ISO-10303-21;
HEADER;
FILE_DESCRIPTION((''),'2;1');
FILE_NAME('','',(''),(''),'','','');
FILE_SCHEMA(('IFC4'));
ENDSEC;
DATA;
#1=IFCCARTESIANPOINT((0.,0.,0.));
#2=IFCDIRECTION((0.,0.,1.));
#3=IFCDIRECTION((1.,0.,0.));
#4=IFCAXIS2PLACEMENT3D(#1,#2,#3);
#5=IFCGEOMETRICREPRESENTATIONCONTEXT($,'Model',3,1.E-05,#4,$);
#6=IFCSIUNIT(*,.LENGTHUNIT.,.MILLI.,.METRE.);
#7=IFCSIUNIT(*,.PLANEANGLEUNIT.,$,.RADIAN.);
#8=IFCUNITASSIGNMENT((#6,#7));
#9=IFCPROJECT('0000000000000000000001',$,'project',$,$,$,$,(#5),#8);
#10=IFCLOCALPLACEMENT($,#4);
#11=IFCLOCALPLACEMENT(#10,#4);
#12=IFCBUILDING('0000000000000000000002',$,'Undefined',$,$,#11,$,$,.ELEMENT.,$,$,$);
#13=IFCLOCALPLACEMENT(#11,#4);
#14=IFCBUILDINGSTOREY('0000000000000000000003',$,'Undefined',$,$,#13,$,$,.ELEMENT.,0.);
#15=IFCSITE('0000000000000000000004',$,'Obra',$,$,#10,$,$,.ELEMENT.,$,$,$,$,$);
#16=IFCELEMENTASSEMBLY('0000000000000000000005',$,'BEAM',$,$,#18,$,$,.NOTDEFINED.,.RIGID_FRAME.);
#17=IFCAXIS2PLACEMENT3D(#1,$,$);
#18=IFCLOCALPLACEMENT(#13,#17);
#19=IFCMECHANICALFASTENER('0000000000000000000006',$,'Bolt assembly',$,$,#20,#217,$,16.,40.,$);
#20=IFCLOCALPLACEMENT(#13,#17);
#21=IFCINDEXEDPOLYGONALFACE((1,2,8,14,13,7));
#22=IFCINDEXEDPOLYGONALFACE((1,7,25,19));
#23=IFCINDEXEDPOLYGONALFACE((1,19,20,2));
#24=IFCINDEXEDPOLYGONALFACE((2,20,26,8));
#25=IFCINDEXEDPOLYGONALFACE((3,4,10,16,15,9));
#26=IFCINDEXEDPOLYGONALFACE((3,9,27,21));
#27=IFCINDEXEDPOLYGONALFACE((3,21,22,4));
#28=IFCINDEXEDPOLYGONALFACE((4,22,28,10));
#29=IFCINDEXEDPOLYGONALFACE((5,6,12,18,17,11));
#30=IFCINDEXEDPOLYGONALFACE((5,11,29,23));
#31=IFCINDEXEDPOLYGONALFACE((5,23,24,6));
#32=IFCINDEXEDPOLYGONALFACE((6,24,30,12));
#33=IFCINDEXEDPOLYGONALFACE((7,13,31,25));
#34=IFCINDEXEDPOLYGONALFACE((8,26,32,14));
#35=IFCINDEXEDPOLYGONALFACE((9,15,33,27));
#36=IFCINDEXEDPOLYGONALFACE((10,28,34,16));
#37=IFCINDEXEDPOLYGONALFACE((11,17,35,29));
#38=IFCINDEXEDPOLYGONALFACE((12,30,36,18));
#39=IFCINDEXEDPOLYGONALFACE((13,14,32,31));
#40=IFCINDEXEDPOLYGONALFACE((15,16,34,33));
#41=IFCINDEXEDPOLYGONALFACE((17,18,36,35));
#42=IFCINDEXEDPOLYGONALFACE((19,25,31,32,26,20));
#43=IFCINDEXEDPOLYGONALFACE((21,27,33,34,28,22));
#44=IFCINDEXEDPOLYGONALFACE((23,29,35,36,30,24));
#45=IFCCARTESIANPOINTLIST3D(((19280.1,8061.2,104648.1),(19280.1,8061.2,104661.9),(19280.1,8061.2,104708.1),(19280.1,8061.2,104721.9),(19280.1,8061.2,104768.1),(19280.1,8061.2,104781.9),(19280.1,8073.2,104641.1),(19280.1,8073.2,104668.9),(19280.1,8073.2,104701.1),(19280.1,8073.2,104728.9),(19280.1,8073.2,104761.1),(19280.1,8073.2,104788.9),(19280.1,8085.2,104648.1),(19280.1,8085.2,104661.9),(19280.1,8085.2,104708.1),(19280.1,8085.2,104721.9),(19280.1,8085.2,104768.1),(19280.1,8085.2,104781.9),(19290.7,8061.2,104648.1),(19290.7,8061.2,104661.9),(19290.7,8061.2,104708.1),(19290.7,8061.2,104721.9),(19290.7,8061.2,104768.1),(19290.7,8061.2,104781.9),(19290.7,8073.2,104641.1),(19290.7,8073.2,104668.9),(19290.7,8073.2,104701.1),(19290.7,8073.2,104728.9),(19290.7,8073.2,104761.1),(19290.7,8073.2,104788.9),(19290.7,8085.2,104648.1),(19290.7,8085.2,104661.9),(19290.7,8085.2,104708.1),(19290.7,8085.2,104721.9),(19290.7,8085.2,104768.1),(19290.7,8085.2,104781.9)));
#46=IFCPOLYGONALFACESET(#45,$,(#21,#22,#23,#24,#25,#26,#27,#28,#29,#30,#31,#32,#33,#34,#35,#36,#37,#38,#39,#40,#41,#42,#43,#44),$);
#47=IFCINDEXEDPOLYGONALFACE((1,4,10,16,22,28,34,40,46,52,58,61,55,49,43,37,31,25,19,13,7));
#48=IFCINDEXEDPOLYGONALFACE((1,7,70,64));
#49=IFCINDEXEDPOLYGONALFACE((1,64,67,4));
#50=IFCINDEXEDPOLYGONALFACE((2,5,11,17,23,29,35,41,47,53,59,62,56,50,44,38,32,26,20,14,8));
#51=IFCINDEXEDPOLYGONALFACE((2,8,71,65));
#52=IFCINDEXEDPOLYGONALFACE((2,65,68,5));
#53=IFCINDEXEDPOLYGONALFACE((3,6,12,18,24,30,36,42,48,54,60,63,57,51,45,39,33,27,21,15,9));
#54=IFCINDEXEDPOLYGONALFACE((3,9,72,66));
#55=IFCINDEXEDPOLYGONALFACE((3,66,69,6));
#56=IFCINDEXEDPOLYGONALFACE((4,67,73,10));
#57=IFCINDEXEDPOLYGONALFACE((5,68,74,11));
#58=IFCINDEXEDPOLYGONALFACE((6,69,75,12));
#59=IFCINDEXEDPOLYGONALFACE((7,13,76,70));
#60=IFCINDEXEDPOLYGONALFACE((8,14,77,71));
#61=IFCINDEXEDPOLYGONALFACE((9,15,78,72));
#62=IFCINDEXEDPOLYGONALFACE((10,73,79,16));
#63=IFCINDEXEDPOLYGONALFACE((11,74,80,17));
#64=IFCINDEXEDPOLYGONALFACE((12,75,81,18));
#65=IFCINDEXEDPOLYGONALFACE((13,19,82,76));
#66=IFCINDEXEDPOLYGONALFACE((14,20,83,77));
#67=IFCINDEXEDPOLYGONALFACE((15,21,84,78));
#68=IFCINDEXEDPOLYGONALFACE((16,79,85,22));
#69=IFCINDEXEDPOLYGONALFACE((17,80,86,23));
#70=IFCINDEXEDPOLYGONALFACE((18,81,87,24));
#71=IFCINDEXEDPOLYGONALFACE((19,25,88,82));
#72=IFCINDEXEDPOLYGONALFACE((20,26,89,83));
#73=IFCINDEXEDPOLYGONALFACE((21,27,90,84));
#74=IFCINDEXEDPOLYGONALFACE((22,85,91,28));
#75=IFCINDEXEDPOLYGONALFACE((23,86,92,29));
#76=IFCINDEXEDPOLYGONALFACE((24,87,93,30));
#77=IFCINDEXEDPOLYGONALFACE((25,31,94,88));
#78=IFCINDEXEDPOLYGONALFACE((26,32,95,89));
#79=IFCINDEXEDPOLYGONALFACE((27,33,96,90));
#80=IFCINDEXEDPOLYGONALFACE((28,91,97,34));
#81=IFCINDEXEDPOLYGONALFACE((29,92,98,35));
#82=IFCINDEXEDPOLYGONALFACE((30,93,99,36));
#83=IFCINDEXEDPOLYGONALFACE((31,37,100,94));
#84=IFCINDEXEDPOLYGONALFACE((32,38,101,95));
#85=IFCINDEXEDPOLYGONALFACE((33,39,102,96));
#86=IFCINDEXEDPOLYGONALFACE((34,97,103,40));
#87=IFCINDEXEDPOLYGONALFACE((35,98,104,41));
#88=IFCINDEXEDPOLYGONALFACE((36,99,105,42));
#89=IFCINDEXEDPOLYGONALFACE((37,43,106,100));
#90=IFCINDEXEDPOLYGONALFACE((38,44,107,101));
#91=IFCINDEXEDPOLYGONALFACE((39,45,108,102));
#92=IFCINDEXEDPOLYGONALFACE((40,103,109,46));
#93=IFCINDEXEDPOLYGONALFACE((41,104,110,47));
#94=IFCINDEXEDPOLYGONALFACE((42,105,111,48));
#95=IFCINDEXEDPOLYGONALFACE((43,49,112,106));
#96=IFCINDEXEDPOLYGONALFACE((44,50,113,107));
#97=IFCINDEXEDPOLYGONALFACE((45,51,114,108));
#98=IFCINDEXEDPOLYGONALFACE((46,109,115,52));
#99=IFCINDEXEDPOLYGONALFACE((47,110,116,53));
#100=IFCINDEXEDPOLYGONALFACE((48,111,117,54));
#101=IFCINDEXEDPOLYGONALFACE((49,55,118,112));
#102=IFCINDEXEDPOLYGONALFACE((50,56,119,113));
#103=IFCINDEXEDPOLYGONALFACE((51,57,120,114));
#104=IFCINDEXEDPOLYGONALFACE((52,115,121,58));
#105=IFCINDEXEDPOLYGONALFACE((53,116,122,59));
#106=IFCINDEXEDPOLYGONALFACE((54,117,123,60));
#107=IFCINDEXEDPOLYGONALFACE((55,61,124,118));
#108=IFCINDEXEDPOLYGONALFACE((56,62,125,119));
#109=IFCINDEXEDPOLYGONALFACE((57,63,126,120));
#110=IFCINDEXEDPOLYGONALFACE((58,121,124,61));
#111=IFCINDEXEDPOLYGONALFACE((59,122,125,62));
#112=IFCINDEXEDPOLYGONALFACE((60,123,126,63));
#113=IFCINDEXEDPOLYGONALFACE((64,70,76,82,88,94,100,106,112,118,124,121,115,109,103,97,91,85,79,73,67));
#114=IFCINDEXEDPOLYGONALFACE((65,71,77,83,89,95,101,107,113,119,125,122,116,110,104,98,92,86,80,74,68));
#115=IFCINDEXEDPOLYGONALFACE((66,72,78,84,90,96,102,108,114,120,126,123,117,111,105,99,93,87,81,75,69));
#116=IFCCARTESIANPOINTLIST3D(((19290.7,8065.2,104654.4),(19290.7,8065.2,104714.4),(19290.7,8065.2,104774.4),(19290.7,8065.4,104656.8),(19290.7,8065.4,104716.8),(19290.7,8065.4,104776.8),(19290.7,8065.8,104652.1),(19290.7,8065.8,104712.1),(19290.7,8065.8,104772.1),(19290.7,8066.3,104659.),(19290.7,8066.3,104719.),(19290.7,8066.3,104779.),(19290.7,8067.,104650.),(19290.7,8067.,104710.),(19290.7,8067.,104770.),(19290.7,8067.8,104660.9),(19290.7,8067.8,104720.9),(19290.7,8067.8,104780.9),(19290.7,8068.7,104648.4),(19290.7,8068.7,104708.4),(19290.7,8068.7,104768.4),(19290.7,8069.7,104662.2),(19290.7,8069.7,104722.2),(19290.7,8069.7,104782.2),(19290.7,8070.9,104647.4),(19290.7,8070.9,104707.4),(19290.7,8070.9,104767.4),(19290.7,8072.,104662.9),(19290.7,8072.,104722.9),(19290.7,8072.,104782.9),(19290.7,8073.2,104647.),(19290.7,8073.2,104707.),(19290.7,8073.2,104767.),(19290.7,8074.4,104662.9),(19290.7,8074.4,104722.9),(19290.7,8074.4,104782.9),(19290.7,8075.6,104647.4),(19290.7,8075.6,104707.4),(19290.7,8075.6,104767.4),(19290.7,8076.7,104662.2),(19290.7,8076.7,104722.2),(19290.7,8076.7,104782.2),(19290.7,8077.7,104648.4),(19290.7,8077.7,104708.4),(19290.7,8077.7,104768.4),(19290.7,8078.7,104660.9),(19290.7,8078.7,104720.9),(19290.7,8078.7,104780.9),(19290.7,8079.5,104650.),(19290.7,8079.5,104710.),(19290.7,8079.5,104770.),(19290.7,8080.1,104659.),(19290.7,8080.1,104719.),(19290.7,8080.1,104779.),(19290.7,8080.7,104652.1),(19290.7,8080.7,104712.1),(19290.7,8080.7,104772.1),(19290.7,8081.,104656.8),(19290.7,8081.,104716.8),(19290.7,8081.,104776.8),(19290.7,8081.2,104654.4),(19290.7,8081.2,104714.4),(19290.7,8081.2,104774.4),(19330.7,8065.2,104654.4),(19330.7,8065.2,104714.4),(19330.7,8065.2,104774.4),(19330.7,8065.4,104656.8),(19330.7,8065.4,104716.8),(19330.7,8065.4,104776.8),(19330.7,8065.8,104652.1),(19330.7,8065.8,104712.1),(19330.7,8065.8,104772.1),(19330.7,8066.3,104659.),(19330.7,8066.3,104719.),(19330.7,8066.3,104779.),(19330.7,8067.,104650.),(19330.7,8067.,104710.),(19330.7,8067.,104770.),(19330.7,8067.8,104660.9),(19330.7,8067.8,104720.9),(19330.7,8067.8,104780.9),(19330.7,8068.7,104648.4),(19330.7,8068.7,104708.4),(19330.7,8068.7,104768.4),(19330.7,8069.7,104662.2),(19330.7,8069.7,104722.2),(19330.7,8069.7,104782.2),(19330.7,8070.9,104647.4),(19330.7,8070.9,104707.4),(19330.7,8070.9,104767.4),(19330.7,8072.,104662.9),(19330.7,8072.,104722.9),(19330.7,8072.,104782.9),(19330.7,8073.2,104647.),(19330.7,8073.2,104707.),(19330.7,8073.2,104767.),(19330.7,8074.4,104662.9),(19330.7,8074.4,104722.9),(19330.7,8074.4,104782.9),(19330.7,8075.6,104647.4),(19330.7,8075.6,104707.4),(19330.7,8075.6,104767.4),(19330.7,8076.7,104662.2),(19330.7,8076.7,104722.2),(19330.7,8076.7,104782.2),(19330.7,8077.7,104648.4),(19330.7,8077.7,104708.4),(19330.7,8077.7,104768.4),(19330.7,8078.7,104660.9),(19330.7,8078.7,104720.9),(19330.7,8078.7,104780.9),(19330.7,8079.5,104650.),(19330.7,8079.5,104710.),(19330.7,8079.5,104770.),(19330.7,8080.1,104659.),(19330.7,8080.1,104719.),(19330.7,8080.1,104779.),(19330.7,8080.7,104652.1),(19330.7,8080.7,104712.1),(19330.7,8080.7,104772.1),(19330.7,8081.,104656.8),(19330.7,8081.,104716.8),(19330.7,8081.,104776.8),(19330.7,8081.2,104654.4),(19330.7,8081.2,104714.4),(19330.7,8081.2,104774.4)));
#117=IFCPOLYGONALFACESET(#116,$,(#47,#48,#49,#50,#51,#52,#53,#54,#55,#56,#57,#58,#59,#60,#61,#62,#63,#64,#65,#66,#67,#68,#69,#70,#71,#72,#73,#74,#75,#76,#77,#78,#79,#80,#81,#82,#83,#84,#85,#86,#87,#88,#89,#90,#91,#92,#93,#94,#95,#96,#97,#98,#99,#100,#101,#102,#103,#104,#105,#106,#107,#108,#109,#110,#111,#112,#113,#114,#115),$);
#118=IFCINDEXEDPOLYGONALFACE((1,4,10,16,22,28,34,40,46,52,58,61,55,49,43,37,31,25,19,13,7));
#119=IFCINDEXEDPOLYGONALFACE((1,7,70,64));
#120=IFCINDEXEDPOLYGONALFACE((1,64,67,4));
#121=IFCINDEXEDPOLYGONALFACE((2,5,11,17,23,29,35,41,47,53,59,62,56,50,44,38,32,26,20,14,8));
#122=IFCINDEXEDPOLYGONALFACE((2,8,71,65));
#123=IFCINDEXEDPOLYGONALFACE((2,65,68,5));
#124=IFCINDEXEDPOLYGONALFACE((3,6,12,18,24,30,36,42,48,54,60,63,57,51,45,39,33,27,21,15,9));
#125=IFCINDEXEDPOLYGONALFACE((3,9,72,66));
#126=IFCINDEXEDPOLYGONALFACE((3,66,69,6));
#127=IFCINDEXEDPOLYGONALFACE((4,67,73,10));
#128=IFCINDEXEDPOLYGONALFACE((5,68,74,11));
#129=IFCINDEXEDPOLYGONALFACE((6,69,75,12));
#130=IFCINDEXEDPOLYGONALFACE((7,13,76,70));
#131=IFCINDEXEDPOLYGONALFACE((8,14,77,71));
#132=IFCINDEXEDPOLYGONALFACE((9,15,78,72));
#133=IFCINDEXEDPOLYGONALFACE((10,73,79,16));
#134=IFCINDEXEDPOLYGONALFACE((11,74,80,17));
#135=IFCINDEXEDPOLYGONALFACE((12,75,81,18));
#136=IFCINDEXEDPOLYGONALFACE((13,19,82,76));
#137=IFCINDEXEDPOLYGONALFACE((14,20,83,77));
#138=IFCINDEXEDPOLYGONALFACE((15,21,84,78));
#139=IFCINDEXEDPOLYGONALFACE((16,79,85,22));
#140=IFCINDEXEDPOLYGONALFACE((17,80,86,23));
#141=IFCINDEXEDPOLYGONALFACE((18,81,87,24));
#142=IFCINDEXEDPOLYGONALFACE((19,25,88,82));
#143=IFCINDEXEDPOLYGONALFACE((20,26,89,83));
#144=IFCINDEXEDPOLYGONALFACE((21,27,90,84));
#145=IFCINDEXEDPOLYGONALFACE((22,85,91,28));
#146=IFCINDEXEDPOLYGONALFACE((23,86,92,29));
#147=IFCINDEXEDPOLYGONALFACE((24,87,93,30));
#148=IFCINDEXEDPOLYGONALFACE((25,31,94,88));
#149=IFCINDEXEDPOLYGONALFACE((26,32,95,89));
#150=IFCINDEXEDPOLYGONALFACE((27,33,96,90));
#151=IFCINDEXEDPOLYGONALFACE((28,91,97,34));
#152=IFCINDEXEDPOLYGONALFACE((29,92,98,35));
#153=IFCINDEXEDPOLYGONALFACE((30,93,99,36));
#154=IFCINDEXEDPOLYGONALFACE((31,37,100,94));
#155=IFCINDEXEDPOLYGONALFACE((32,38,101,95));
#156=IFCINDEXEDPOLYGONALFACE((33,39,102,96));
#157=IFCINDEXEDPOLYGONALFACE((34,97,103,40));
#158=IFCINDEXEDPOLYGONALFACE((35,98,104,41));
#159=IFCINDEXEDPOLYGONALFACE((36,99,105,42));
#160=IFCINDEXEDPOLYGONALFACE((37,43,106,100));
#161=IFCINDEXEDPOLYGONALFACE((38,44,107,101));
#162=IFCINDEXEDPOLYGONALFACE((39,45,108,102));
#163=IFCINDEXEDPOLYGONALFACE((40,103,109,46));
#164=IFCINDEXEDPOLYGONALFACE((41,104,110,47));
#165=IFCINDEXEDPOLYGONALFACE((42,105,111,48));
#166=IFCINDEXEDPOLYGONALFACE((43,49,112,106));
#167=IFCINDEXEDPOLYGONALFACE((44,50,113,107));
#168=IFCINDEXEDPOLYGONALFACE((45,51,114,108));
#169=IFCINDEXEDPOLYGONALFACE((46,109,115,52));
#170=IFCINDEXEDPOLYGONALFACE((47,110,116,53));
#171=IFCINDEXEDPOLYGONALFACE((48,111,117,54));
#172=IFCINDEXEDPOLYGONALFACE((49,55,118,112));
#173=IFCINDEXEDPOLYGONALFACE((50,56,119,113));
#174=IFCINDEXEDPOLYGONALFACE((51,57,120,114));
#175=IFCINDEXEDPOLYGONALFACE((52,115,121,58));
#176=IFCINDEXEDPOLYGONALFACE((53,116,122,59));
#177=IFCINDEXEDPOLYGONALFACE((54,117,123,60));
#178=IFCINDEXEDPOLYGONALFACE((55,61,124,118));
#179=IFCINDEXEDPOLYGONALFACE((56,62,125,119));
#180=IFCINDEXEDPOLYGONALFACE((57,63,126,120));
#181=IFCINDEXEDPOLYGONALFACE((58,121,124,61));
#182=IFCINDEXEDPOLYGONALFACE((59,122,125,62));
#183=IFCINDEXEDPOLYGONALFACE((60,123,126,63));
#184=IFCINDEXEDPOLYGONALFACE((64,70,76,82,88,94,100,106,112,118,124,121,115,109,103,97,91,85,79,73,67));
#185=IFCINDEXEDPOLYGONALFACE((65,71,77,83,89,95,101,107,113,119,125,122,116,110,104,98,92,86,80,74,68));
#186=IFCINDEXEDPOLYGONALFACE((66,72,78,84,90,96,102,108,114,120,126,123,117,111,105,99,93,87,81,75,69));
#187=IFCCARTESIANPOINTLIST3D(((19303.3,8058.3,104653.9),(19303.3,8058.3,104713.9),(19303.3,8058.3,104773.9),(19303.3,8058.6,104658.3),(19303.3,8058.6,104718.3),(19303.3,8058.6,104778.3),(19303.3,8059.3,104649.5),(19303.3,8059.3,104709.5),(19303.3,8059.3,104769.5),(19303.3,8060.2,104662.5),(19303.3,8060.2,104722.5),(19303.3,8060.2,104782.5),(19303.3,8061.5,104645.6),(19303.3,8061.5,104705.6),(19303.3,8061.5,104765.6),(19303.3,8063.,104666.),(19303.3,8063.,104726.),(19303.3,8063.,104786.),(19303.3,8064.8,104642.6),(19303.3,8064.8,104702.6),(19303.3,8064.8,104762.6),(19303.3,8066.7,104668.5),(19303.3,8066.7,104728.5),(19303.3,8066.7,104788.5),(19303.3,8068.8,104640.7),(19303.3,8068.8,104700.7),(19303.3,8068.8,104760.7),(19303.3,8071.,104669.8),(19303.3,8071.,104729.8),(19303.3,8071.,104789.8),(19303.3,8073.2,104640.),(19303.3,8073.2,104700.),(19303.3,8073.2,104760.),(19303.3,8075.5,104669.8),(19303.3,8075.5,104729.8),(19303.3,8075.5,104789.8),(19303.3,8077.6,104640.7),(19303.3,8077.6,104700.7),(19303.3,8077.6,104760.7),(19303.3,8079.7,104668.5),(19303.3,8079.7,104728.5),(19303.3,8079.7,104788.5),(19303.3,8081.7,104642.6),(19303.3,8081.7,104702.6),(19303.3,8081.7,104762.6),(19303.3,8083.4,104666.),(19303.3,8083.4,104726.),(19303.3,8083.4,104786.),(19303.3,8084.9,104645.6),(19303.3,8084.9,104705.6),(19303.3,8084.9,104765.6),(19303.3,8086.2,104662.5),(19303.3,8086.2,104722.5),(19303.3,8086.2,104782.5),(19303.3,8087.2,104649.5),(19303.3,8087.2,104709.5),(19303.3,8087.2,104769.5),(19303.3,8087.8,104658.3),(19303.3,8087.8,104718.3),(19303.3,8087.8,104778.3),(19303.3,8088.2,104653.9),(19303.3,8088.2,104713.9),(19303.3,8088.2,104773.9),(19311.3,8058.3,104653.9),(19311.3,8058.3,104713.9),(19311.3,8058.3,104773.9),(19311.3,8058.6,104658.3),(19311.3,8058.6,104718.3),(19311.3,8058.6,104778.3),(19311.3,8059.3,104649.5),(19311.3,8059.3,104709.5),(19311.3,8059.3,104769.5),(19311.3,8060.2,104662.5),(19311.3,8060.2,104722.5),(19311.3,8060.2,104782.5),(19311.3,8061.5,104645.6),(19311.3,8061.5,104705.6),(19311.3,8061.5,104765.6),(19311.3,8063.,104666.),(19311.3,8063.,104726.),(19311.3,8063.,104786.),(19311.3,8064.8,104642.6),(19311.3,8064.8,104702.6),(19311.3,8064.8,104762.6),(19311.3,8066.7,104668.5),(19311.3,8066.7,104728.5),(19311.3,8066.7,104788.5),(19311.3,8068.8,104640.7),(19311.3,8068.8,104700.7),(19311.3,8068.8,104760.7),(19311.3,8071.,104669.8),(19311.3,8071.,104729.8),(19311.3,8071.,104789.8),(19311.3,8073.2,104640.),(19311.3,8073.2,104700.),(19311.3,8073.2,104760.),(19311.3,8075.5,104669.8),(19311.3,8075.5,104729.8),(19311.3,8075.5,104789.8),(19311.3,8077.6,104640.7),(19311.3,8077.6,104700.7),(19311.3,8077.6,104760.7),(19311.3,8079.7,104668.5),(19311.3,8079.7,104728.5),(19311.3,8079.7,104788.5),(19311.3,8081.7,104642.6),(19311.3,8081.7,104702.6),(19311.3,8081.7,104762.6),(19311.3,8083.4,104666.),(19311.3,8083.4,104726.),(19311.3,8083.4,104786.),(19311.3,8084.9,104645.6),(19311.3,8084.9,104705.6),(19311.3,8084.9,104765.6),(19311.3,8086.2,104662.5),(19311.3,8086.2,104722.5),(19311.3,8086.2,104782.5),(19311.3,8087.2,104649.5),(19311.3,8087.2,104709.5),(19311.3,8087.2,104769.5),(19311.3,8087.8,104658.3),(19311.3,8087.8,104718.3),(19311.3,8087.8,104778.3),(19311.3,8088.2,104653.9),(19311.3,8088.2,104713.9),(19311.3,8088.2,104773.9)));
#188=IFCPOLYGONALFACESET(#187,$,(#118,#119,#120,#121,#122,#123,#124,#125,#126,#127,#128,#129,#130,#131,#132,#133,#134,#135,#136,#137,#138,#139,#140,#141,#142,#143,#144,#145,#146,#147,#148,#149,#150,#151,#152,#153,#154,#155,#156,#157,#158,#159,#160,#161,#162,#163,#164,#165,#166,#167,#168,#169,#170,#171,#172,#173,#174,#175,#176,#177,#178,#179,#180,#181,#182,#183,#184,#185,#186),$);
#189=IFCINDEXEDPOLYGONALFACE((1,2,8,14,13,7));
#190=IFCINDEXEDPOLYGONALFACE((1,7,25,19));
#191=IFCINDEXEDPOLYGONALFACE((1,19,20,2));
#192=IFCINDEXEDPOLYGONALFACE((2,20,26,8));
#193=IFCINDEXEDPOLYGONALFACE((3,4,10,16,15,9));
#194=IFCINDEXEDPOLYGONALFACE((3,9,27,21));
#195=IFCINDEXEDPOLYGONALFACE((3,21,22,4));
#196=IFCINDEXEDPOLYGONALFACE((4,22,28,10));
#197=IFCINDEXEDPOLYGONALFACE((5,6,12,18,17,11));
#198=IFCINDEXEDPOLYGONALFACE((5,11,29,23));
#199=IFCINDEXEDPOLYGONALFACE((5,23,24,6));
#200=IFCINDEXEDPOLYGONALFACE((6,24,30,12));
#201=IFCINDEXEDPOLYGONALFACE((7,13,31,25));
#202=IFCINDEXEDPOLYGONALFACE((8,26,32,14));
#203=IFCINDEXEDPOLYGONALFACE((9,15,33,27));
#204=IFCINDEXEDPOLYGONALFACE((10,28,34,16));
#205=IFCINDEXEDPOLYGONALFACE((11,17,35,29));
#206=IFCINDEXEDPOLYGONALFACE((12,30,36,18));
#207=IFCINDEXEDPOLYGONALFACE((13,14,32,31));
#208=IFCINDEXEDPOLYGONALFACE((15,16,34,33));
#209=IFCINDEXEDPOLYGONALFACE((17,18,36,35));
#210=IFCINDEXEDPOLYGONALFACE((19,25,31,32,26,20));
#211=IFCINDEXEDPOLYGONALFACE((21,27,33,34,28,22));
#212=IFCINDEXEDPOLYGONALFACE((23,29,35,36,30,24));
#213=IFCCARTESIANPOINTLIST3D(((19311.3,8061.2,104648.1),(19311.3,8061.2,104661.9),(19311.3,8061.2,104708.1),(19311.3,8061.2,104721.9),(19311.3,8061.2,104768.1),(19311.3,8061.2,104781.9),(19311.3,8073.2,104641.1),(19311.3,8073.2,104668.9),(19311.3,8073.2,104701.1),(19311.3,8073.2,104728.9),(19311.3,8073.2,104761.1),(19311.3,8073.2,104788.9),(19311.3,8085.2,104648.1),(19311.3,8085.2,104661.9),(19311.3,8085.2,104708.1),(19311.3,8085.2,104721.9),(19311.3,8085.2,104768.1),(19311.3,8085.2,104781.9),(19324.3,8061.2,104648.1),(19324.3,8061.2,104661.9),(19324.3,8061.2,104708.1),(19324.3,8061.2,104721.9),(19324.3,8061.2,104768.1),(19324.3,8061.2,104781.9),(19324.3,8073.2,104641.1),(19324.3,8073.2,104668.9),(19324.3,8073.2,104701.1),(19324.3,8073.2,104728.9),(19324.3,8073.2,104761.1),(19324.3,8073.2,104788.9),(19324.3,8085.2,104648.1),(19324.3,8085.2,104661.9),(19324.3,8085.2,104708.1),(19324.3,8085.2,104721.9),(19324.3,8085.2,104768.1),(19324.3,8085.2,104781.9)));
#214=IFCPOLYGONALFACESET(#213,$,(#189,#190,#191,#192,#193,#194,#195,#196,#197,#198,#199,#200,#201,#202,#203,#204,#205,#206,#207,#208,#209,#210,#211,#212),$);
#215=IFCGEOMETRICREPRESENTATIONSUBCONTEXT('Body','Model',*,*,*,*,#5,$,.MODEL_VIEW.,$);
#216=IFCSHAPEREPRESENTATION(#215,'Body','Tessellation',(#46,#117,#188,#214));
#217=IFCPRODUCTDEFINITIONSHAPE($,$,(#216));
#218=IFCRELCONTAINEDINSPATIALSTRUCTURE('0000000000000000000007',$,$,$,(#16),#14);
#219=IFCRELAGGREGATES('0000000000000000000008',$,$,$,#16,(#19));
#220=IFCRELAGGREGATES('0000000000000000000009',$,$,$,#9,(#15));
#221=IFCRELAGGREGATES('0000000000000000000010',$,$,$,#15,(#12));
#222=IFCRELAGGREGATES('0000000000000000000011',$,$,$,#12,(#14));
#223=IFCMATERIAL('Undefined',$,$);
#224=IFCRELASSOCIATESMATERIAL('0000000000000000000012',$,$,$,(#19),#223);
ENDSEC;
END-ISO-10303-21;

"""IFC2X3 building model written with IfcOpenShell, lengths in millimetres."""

from ifc_helpers import new_model, si_unit, frame, origin_with_axes, origin_2d_with_axis, place, context, subcontext, project, spatial, polyline, circle, outline, extrude, source, transform, mapped, material, element, aggregate, save


model = new_model("IFC2X3")

# Units and contexts
model_context = context("Model", 3, precision=1e-05, world=origin_with_axes())
body_context = subcontext(model_context, "Body", "Model", "MODEL_VIEW")
ifc_project = project(units=[si_unit("LENGTHUNIT", "METRE", prefix="MILLI"), si_unit("PLANEANGLEUNIT", "RADIAN")], contexts=[model_context])

# Site, building, storey
site_placement = place(None, origin_with_axes())
site = spatial("IfcSite", under=ifc_project, at=site_placement, Name="Obra", CompositionType="ELEMENT")
building_placement = place(site_placement, origin_with_axes())
building = spatial("IfcBuilding", under=site, at=building_placement, Name="Undefined", CompositionType="ELEMENT")
storey_placement = place(building_placement, origin_with_axes())
storey = spatial("IfcBuildingStorey", under=building, at=storey_placement, Name="Undefined", CompositionType="ELEMENT", Elevation=0.0)

# Shared definitions
ifc_material_1 = material(Name="Undefined")

# Element assembly, mechanical fastener
shared_shape_1 = source(origin_with_axes(), body_context, "Body", "SweptSolid", [
    extrude(outline(polyline([(13.9, 0.0), (6.9, 12.0), (-6.9, 12.0), (-13.9, 0.0), (-6.9, -12.0), (6.9, -12.0), (13.9, 0.0)])), frame((0.0, -19.9, 0.0), z_axis=(0.0, 1.0, 0.0), x_axis=(1.0, 0.0, 0.0)), (0.0, 0.0, 1.0), 10.6),
    extrude(circle(Radius=8.0, at=origin_2d_with_axis()), frame((0.0, -9.3, 0.0), z_axis=(0.0, 1.0, 0.0), x_axis=(1.0, 0.0, 0.0)), (0.0, 0.0, 1.0), 40.0),
    extrude(circle(Radius=15.0, at=origin_2d_with_axis()), frame((0.0, 3.3, 0.0), z_axis=(0.0, 1.0, 0.0), x_axis=(1.0, 0.0, 0.0)), (0.0, 0.0, 1.0), 8.0),
    extrude(outline(polyline([(13.9, 0.0), (6.9, 12.0), (-6.9, 12.0), (-13.9, 0.0), (-6.9, -12.0), (6.9, -12.0), (13.9, 0.0)])), frame((0.0, 11.3, 0.0), z_axis=(0.0, 1.0, 0.0), x_axis=(1.0, 0.0, 0.0)), (0.0, 0.0, 1.0), 13.0),
])
assembly_1_placement = place(storey_placement, origin_with_axes())
assembly_1 = element("IfcElementAssembly", 1, at=assembly_1_placement, inside=storey, Name="BEAM", AssemblyPlace="NOTDEFINED", PredefinedType="RIGID_FRAME")
mechanical_fastener_1_placement = place(assembly_1_placement, frame((19300.0, 8108.2, 104850.0), z_axis=(0.0, -1.0, 0.0), x_axis=(0.0, 0.0, -1.0)))
mechanical_fastener_1 = element("IfcMechanicalFastener", 2, at=mechanical_fastener_1_placement, material=ifc_material_1, Name="Bolt assembly", NominalDiameter=16.0, NominalLength=40.0, context=body_context, shape_type="MappedRepresentation", body=[
    mapped(shared_shape_1, transform((75.0, 0.0, 35.0))),
    mapped(shared_shape_1, transform((135.0, 0.0, 35.0))),
    mapped(shared_shape_1, transform((195.0, 0.0, 35.0))),
])
aggregate(assembly_1, [mechanical_fastener_1])

save(model, "model.ifc")
